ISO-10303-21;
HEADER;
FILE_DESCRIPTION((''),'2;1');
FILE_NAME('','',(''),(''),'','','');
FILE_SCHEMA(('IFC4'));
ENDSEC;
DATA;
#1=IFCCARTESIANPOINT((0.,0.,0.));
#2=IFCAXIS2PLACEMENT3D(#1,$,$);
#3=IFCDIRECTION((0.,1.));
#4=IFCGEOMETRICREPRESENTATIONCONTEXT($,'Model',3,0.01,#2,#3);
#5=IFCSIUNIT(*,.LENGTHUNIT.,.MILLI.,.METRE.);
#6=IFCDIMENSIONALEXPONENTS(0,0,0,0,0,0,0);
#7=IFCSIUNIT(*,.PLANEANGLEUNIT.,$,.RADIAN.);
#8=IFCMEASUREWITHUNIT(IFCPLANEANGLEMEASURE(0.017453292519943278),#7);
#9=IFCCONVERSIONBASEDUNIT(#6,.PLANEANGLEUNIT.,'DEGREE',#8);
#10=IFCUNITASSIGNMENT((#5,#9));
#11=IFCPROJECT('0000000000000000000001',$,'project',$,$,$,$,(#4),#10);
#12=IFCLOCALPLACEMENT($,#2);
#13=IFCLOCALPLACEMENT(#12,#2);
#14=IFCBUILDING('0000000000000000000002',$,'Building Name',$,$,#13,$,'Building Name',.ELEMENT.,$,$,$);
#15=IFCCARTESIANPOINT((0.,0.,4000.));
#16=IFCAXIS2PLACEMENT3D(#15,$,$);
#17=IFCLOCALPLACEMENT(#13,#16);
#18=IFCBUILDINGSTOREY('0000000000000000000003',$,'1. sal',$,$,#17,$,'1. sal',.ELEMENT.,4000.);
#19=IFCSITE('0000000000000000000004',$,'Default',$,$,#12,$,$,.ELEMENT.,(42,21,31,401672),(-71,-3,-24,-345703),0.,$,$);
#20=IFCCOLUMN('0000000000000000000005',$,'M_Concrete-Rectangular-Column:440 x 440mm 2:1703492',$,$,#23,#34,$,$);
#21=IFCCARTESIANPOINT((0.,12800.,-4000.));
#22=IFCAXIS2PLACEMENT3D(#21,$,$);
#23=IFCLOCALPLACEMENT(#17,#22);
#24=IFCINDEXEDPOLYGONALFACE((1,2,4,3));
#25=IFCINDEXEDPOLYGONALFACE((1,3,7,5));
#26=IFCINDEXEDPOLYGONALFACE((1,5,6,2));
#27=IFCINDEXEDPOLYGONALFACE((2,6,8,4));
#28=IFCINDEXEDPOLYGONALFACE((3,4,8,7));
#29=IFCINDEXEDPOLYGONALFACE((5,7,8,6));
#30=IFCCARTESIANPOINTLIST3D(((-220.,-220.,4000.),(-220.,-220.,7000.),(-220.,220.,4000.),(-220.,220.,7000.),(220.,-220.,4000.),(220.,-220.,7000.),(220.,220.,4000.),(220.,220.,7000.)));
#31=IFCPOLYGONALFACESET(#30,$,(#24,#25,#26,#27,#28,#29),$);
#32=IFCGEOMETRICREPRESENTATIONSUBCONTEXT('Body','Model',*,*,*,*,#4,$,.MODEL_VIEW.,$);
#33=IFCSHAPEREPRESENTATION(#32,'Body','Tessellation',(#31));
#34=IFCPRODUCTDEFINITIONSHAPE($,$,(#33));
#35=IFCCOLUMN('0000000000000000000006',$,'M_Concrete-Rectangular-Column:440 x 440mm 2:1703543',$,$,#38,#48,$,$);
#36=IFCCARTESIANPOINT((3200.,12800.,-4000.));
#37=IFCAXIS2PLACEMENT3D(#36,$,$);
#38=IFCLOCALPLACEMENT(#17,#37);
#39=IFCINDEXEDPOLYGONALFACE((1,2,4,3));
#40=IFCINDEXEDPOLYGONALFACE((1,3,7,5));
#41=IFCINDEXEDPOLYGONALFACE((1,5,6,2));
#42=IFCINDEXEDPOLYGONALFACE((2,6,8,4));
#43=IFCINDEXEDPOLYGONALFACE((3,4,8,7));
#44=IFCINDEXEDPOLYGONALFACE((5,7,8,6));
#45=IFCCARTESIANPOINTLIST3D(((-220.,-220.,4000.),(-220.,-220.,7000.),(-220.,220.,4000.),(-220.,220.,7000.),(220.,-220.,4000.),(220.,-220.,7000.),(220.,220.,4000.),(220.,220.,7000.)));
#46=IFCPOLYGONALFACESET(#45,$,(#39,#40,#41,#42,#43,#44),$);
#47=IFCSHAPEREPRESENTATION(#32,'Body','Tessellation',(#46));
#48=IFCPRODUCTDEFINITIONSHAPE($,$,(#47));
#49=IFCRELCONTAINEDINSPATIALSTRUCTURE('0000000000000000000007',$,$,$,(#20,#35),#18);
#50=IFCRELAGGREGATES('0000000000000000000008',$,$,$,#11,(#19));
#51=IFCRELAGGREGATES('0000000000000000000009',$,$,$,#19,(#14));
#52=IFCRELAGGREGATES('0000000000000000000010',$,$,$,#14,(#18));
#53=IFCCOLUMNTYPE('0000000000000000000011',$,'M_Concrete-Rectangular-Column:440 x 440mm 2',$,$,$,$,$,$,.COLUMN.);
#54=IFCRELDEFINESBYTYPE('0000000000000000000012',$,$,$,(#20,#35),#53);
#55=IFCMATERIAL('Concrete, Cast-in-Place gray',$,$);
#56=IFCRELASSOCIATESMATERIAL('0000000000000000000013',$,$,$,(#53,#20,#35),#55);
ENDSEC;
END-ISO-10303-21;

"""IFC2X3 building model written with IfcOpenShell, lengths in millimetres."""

from ifc_helpers import new_model, entity, si_unit, converted_unit, direction, frame, origin, origin_2d_with_axis, place, context, subcontext, project, spatial, rectangle, extrude, source, transform, mapped, material, type_object, type_shapes, element, save


model = new_model("IFC2X3")

# Units and contexts
model_context = context("Model", 3, precision=0.01, world=origin(), true_north=direction((0.0, 1.0)))
body_context = subcontext(model_context, "Body", "Model", "MODEL_VIEW")
ifc_project = project(units=[si_unit("LENGTHUNIT", "METRE", prefix="MILLI"), converted_unit("PLANEANGLEUNIT", "DEGREE", entity("IfcPlaneAngleMeasure", 0.017453292519943278), si_unit("PLANEANGLEUNIT", "RADIAN"), dimensions=[0, 0, 0, 0, 0, 0, 0])], contexts=[model_context])

# Site, building, storey
site_placement = place(None, origin())
site = spatial("IfcSite", under=ifc_project, at=site_placement, Name="Default", CompositionType="ELEMENT", RefLatitude=(42, 21, 31, 401672), RefLongitude=(-71, -3, -24, -345703), RefElevation=0.0)
building_placement = place(site_placement, origin())
building = spatial("IfcBuilding", under=site, at=building_placement, Name="Building Name", LongName="Building Name", CompositionType="ELEMENT")
storey_placement = place(building_placement, frame((0.0, 0.0, 4000.0)))
storey = spatial("IfcBuildingStorey", under=building, at=storey_placement, Name="1. sal", LongName="1. sal", CompositionType="ELEMENT", Elevation=4000.0)

# Columns
ifc_material_1 = material(Name="Concrete, Cast-in-Place gray")
column_type = type_object("IfcColumnType", Name="M_Concrete-Rectangular-Column:440 x 440mm 2", PredefinedType="COLUMN", material=ifc_material_1)
shared_shape_1 = source(origin(), body_context, "Body", "SweptSolid", [
    extrude(rectangle(XDim=440.0, YDim=440.0, at=origin_2d_with_axis()), frame((0.0, 0.0, 4000.0), z_axis=(0.0, 0.0, 1.0), x_axis=(-1.0, 0.0, 0.0)), (0.0, 0.0, 1.0), 3000.0),
])
type_shapes(column_type, [shared_shape_1])
for number, where, name in (
    (1, (0.0, 12800.0, -4000.0), "M_Concrete-Rectangular-Column:440 x 440mm 2:1703492"),
    (2, (3200.0, 12800.0, -4000.0), "M_Concrete-Rectangular-Column:440 x 440mm 2:1703543"),
):
    element("IfcColumn", number, at=place(storey_placement, frame(where)), inside=storey, type_object=column_type, material=ifc_material_1, Name=name, context=body_context, shape_type="MappedRepresentation", body=[
        mapped(shared_shape_1, transform((0.0, 0.0, 0.0), scale=1.0)),
    ])

save(model, "model.ifc")
